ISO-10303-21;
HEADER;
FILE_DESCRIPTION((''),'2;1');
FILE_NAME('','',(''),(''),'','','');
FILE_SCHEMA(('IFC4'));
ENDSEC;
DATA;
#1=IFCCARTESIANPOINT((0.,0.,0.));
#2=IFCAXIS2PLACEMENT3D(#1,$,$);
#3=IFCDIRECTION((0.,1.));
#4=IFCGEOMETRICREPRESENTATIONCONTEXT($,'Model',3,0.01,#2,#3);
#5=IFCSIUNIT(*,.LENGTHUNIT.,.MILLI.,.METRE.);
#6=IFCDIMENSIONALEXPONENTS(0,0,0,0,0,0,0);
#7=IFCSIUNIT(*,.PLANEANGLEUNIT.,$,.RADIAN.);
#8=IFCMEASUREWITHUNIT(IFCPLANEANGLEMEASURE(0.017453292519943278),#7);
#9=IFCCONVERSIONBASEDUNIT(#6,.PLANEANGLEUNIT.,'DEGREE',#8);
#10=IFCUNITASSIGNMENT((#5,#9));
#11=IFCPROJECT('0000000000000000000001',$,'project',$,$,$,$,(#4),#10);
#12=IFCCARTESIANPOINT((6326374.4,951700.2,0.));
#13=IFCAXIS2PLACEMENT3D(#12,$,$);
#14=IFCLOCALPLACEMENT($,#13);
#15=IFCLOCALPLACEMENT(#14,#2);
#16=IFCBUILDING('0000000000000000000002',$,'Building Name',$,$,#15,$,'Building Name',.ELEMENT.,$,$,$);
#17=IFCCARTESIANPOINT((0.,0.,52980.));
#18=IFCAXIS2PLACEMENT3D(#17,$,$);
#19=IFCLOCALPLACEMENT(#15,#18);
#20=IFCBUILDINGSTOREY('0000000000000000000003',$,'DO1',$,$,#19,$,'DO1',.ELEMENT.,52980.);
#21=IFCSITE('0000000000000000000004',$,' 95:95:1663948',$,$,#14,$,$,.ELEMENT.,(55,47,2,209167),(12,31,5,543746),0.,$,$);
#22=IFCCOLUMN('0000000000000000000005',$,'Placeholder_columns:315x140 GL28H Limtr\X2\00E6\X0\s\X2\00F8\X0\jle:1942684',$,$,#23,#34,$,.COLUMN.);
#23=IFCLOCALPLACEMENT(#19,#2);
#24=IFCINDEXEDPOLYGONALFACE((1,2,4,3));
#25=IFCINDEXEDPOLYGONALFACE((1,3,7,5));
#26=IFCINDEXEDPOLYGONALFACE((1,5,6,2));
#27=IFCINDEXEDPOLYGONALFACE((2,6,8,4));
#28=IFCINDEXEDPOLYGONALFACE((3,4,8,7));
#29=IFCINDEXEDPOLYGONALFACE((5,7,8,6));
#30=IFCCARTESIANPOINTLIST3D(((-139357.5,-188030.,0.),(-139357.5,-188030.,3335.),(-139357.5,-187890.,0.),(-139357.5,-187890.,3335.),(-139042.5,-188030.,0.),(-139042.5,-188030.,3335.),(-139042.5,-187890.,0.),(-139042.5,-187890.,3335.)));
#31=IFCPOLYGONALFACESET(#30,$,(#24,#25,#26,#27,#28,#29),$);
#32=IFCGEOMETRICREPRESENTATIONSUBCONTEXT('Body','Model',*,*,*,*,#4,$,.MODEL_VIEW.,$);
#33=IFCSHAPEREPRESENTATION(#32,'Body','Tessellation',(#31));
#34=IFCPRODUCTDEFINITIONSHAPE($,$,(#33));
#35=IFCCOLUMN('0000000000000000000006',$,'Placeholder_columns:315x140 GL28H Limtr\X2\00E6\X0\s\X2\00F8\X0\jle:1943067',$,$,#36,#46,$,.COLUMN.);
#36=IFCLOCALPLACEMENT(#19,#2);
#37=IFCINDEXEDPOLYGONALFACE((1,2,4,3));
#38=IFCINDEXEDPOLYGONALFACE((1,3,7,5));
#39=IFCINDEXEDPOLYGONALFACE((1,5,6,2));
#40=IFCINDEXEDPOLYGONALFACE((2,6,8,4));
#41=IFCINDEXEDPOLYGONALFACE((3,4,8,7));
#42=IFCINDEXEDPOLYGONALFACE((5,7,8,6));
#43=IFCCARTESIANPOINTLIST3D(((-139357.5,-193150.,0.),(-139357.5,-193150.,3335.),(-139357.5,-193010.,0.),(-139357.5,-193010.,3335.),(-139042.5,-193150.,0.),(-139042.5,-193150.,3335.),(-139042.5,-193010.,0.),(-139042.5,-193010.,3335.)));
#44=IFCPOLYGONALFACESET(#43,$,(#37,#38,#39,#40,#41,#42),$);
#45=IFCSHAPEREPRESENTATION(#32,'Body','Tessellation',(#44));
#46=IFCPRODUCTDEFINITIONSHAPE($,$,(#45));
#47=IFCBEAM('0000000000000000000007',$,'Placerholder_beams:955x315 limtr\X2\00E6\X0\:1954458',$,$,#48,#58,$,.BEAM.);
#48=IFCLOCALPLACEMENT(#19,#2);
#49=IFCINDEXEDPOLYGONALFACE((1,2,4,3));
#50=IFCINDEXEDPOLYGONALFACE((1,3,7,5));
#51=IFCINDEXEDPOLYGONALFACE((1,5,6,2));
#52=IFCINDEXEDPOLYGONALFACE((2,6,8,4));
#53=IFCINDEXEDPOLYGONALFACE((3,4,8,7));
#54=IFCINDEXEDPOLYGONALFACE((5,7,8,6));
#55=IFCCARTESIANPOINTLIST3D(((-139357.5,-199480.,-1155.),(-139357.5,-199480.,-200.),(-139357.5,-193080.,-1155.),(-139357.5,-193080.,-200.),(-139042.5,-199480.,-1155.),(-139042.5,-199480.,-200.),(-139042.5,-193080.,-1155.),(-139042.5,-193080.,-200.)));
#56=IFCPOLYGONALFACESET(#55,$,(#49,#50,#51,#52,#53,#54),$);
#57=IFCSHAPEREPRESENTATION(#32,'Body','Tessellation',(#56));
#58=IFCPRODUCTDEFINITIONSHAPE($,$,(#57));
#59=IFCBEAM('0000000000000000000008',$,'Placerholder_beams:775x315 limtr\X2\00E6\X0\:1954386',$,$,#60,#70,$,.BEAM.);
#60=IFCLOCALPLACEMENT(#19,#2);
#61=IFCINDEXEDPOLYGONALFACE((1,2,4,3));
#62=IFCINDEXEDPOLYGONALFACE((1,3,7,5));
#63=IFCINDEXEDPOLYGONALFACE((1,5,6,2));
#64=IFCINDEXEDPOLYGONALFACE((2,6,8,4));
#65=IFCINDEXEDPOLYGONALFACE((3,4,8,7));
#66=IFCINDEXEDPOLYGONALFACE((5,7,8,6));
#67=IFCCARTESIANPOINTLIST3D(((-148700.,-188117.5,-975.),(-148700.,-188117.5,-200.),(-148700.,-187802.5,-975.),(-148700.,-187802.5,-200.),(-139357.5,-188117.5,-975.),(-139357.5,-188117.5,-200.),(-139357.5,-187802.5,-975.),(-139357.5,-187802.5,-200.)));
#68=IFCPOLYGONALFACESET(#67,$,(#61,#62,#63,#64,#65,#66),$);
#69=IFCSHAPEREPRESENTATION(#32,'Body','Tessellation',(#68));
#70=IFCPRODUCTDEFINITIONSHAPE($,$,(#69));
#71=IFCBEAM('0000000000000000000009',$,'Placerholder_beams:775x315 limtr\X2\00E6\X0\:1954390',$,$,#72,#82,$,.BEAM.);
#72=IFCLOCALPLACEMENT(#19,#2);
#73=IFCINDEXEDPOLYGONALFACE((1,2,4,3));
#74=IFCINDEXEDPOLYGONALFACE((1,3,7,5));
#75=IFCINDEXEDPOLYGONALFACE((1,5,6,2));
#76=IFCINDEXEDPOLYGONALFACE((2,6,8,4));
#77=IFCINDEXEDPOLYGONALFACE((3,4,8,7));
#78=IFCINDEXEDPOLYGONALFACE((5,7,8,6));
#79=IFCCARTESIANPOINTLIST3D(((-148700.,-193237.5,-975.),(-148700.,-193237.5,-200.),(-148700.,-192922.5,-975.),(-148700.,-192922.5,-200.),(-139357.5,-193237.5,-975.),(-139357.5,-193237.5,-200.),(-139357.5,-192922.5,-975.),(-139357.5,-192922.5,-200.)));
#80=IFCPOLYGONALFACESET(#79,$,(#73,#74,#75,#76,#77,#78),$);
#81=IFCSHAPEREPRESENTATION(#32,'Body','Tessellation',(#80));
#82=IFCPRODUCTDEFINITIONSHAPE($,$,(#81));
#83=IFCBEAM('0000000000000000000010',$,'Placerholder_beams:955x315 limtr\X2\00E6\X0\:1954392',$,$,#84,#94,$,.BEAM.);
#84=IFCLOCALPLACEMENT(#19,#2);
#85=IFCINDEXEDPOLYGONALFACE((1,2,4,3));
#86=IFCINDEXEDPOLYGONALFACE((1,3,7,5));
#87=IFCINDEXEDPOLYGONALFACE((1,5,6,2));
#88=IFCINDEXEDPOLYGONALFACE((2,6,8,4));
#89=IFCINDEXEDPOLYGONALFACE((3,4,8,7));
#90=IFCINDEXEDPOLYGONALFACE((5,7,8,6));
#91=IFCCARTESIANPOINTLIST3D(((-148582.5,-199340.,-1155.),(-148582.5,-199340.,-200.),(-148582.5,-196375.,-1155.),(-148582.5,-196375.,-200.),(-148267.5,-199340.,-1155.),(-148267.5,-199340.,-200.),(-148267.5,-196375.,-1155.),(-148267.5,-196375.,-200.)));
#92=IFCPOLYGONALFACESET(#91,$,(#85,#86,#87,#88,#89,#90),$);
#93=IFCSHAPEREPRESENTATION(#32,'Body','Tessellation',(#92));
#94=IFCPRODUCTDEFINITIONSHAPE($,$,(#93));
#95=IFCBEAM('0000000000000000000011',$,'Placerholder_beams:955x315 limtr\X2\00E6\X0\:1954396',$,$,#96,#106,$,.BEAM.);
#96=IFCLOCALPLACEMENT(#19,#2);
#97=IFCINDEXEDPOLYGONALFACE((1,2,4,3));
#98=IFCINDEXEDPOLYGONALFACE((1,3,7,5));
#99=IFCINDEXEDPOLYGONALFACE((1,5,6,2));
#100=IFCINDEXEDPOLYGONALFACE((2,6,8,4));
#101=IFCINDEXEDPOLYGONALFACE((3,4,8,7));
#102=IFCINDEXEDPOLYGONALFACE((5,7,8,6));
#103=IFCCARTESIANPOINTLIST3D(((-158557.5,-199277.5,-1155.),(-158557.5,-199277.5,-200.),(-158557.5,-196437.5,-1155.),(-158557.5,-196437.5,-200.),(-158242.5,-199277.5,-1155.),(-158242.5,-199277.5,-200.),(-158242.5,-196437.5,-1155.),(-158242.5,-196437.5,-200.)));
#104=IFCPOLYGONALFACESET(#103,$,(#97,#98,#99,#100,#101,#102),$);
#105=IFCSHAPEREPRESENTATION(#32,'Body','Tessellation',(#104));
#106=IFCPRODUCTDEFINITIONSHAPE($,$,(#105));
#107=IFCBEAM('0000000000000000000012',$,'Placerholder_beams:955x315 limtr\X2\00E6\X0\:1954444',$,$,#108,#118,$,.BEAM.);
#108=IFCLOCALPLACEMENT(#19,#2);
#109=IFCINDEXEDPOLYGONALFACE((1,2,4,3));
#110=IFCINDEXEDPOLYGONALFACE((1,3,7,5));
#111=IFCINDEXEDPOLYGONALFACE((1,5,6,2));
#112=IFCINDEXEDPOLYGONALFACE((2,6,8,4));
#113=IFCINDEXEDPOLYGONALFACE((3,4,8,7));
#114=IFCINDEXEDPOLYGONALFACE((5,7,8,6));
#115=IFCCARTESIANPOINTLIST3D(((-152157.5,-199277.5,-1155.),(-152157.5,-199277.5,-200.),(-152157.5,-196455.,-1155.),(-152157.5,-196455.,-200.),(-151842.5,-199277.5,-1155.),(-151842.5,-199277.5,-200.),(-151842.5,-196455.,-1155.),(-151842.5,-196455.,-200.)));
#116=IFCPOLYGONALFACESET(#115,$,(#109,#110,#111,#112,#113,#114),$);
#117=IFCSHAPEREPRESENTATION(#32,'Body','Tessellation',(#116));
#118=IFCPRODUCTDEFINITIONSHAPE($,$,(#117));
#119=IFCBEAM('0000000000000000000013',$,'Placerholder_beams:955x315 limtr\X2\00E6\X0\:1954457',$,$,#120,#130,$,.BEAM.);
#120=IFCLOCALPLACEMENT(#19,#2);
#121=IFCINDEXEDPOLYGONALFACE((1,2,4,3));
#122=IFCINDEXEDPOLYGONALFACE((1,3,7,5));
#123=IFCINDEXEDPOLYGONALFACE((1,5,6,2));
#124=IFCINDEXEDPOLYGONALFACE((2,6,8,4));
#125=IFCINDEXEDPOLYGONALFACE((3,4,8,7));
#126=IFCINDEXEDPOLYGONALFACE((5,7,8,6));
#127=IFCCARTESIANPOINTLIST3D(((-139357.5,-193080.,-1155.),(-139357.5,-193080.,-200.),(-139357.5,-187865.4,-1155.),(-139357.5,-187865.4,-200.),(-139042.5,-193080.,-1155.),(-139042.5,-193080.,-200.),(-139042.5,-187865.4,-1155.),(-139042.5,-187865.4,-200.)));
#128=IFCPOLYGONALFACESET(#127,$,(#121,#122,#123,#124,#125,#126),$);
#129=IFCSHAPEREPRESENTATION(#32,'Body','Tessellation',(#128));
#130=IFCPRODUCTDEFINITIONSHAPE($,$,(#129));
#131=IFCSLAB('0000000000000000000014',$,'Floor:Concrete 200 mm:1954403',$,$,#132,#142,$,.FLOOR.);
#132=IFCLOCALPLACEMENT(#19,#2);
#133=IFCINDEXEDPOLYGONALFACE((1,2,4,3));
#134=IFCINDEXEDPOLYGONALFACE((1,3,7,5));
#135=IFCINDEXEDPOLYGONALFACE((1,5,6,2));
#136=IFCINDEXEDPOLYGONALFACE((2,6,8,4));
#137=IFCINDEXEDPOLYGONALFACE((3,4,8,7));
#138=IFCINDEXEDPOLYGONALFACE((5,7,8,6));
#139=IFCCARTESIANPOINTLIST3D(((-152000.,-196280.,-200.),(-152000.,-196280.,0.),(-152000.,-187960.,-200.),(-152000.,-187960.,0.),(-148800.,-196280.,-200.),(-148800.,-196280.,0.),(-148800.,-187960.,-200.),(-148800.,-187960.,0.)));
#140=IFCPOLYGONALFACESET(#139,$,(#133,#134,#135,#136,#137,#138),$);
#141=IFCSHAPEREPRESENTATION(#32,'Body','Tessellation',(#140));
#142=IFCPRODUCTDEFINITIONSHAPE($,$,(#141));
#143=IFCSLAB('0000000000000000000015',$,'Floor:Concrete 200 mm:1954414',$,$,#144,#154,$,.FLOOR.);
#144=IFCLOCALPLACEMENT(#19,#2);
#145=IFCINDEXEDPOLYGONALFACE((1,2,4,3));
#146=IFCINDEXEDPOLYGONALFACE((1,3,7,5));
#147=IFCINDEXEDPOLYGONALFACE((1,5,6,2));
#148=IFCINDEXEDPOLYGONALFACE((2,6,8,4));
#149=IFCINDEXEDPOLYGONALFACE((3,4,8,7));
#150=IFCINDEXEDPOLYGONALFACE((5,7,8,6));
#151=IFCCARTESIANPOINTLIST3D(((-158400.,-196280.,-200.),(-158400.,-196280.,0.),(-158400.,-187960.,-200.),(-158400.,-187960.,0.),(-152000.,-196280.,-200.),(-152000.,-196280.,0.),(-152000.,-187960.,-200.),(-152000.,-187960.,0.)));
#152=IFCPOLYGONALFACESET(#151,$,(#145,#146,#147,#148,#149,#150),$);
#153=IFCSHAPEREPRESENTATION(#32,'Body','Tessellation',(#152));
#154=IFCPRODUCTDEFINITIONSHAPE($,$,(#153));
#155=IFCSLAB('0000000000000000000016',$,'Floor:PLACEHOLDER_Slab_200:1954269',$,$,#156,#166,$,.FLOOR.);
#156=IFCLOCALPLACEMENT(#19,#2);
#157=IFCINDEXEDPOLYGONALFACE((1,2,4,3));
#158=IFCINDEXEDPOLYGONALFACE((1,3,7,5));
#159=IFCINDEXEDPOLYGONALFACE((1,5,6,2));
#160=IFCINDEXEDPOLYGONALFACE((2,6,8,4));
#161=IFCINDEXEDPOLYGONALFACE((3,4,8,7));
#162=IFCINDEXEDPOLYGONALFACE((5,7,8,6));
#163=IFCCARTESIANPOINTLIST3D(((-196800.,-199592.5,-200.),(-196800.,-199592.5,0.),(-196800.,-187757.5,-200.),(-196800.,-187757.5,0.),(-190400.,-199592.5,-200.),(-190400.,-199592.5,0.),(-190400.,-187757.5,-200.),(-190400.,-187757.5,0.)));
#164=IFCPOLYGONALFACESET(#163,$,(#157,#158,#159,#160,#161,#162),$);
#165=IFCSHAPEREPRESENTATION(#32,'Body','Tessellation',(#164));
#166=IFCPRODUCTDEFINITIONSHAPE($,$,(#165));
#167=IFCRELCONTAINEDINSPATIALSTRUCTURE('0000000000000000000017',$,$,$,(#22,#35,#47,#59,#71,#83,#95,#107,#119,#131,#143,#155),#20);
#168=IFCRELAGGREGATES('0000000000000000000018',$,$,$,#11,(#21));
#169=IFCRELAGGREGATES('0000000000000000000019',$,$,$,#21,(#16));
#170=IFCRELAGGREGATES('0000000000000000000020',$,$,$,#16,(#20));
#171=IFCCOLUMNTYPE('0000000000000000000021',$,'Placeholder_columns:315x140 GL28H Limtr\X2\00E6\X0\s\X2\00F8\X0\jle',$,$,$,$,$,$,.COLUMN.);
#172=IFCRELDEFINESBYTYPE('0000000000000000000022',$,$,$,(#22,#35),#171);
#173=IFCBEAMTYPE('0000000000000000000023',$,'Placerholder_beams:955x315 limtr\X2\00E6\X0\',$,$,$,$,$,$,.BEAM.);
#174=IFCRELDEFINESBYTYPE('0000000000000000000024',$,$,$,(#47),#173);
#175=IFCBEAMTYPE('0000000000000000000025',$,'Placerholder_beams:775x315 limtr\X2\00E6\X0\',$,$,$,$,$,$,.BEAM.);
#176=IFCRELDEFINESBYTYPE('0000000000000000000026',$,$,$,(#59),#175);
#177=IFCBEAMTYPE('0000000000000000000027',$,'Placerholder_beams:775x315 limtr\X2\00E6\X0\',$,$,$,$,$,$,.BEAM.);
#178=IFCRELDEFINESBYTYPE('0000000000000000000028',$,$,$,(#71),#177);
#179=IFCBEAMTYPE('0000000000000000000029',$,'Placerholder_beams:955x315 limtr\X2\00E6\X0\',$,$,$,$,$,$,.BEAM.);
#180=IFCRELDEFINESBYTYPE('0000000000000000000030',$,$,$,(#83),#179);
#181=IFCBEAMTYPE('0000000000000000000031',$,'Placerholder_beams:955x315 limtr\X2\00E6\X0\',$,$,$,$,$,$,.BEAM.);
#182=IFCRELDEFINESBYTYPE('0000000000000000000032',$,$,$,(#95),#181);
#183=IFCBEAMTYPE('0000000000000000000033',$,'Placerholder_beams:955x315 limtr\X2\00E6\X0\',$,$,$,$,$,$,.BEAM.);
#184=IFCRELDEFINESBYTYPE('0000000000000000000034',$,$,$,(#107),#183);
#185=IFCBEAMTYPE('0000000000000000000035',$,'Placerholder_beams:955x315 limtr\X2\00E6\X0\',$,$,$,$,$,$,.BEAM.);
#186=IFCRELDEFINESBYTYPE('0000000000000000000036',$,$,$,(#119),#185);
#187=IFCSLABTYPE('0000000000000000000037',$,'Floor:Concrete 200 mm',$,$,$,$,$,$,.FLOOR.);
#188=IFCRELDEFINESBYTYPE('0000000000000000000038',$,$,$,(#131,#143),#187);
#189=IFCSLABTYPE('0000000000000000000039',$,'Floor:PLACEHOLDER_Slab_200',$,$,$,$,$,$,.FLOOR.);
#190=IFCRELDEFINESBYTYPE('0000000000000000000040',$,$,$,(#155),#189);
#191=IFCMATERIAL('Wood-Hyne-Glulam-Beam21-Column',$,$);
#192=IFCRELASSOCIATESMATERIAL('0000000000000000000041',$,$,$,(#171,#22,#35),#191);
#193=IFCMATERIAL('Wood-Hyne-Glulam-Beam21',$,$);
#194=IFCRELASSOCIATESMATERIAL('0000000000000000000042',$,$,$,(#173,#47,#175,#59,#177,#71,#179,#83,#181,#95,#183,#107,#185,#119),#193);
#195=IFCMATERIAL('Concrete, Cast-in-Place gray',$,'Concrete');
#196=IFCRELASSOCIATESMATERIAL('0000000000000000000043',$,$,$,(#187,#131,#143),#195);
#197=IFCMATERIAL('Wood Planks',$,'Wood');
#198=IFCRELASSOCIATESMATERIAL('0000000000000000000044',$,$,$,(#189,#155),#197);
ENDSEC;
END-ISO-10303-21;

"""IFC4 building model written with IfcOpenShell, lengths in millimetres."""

from ifc_helpers import new_model, entity, si_unit, converted_unit, direction, frame, origin, place, context, subcontext, project, spatial, indexed_curve, outline, extrude, source, transform, mapped, material, type_object, type_shapes, element, save


model = new_model("IFC4")

# Units and contexts
model_context = context("Model", 3, precision=0.01, world=origin(), true_north=direction((0.0, 1.0)))
body_context = subcontext(model_context, "Body", "Model", "MODEL_VIEW")
ifc_project = project(units=[si_unit("LENGTHUNIT", "METRE", prefix="MILLI"), converted_unit("PLANEANGLEUNIT", "DEGREE", entity("IfcPlaneAngleMeasure", 0.017453292519943278), si_unit("PLANEANGLEUNIT", "RADIAN"), dimensions=[0, 0, 0, 0, 0, 0, 0])], contexts=[model_context])

# Site, building, storey
site_placement = place(None, frame((6326374.4, 951700.2, 0.0)))
site = spatial("IfcSite", under=ifc_project, at=site_placement, Name=" 95:95:1663948", CompositionType="ELEMENT", RefLatitude=(55, 47, 2, 209167), RefLongitude=(12, 31, 5, 543746), RefElevation=0.0)
building_placement = place(site_placement, origin())
building = spatial("IfcBuilding", under=site, at=building_placement, Name="Building Name", LongName="Building Name", CompositionType="ELEMENT")
storey_placement = place(building_placement, frame((0.0, 0.0, 52980.0)))
storey = spatial("IfcBuildingStorey", under=building, at=storey_placement, Name="DO1", LongName="DO1", CompositionType="ELEMENT", Elevation=52980.0)

# Columns
ifc_material_1 = material(Name="Wood-Hyne-Glulam-Beam21-Column")
column_type = type_object("IfcColumnType", Name="Placeholder_columns:315x140 GL28H Limtræsøjle", PredefinedType="COLUMN", material=ifc_material_1)
shared_shape_1 = source(origin(), body_context, "Body", "SweptSolid", [
    extrude(outline(indexed_curve([(-157.5, -70.0), (157.5, -70.0), (157.5, 70.0), (-157.5, 70.0), (-157.5, -70.0)], self_intersect=False)), frame((0.0, 0.0, 52980.0), z_axis=(0.0, 0.0, 1.0), x_axis=(-1.0, 0.0, 0.0)), (0.0, 0.0, 1.0), 3335.0),
])
type_shapes(column_type, [shared_shape_1])
for number, where, name in (
    (1, (-139200.0, -187960.0, -52980.0), "Placeholder_columns:315x140 GL28H Limtræsøjle:1942684"),
    (2, (-139200.0, -193080.0, -52980.0), "Placeholder_columns:315x140 GL28H Limtræsøjle:1943067"),
):
    element("IfcColumn", number, at=place(storey_placement, frame(where)), inside=storey, type_object=column_type, material=ifc_material_1, Name=name, PredefinedType="COLUMN", context=body_context, shape_type="MappedRepresentation", body=[
        mapped(shared_shape_1, transform((0.0, 0.0, 0.0), scale=1.0)),
    ])

# Beams
ifc_material_2 = material(Name="Wood-Hyne-Glulam-Beam21")
beam_type_1 = type_object("IfcBeamType", Name="Placerholder_beams:955x315 limtræ", PredefinedType="BEAM", material=ifc_material_2)
shared_shape_2 = source(origin(), body_context, "Body", "SweptSolid", [
    extrude(outline(indexed_curve([(-3200.0, -157.5), (3200.0, -157.5), (3200.0, 157.5), (-3200.0, 157.5), (-3200.0, -157.5)], self_intersect=False)), frame((0.0, 0.0, -477.5)), (0.0, 0.0, 1.0), 955.0),
])
type_shapes(beam_type_1, [shared_shape_2])
beam_1_placement = place(storey_placement, frame((-139200.0, -196280.0, -677.5), z_axis=(0.0, 0.0, 1.0), x_axis=(0.0, -1.0, 0.0)))
element("IfcBeam", 3, at=beam_1_placement, inside=storey, type_object=beam_type_1, material=ifc_material_2, Name="Placerholder_beams:955x315 limtræ:1954458", PredefinedType="BEAM", context=body_context, shape_type="MappedRepresentation", body=[
    mapped(shared_shape_2, transform((0.0, 0.0, 0.0), scale=1.0)),
])
beam_type_2 = type_object("IfcBeamType", Name="Placerholder_beams:775x315 limtræ", PredefinedType="BEAM", material=ifc_material_2)
shared_shape_3 = source(origin(), body_context, "Body", "SweptSolid", [
    extrude(outline(indexed_curve([(-4671.3, -157.5), (4671.3, -157.5), (4671.3, 157.5), (-4671.3, 157.5), (-4671.3, -157.5)], self_intersect=False)), frame((28.7, 0.0, -387.5)), (0.0, 0.0, 1.0), 775.0),
])
type_shapes(beam_type_2, [shared_shape_3])
beam_2_placement = place(storey_placement, frame((-144000.0, -187960.0, -587.5), z_axis=(0.0, 0.0, 1.0), x_axis=(-1.0, 0.0, 0.0)))
element("IfcBeam", 4, at=beam_2_placement, inside=storey, type_object=beam_type_2, material=ifc_material_2, Name="Placerholder_beams:775x315 limtræ:1954386", PredefinedType="BEAM", context=body_context, shape_type="MappedRepresentation", body=[
    mapped(shared_shape_3, transform((0.0, 0.0, 0.0), scale=1.0)),
])
beam_type_3 = type_object("IfcBeamType", Name="Placerholder_beams:775x315 limtræ", PredefinedType="BEAM", material=ifc_material_2)
shared_shape_4 = source(origin(), body_context, "Body", "SweptSolid", [
    extrude(outline(indexed_curve([(-4671.3, -157.5), (4671.3, -157.5), (4671.3, 157.5), (-4671.3, 157.5), (-4671.3, -157.5)], self_intersect=False)), frame((-28.7, 0.0, -387.5)), (0.0, 0.0, 1.0), 775.0),
])
type_shapes(beam_type_3, [shared_shape_4])
beam_3_placement = place(storey_placement, frame((-144000.0, -193080.0, -587.5)))
element("IfcBeam", 5, at=beam_3_placement, inside=storey, type_object=beam_type_3, material=ifc_material_2, Name="Placerholder_beams:775x315 limtræ:1954390", PredefinedType="BEAM", context=body_context, shape_type="MappedRepresentation", body=[
    mapped(shared_shape_4, transform((0.0, 0.0, 0.0), scale=1.0)),
])
beam_type_4 = type_object("IfcBeamType", Name="Placerholder_beams:955x315 limtræ", PredefinedType="BEAM", material=ifc_material_2)
shared_shape_5 = source(origin(), body_context, "Body", "SweptSolid", [
    extrude(outline(indexed_curve([(-1482.5, -157.5), (1482.5, -157.5), (1482.5, 157.5), (-1482.5, 157.5), (-1482.5, -157.5)], self_intersect=False)), frame((22.5, 0.0, -477.5)), (0.0, 0.0, 1.0), 955.0),
])
type_shapes(beam_type_4, [shared_shape_5])
beam_4_placement = place(storey_placement, frame((-148425.0, -197880.0, -677.5), z_axis=(0.0, 0.0, 1.0), x_axis=(0.0, 1.0, 0.0)))
element("IfcBeam", 6, at=beam_4_placement, inside=storey, type_object=beam_type_4, material=ifc_material_2, Name="Placerholder_beams:955x315 limtræ:1954392", PredefinedType="BEAM", context=body_context, shape_type="MappedRepresentation", body=[
    mapped(shared_shape_5, transform((0.0, 0.0, 0.0), scale=1.0)),
])
beam_type_5 = type_object("IfcBeamType", Name="Placerholder_beams:955x315 limtræ", PredefinedType="BEAM", material=ifc_material_2)
shared_shape_6 = source(origin(), body_context, "Body", "SweptSolid", [
    extrude(outline(indexed_curve([(-1420.0, -157.5), (1420.0, -157.5), (1420.0, 157.5), (-1420.0, 157.5), (-1420.0, -157.5)], self_intersect=False)), frame((0.0, 0.0, -477.5)), (0.0, 0.0, 1.0), 955.0),
])
type_shapes(beam_type_5, [shared_shape_6])
beam_5_placement = place(storey_placement, frame((-158400.0, -197857.5, -677.5), z_axis=(0.0, 0.0, 1.0), x_axis=(0.0, 1.0, 0.0)))
element("IfcBeam", 7, at=beam_5_placement, inside=storey, type_object=beam_type_5, material=ifc_material_2, Name="Placerholder_beams:955x315 limtræ:1954396", PredefinedType="BEAM", context=body_context, shape_type="MappedRepresentation", body=[
    mapped(shared_shape_6, transform((0.0, 0.0, 0.0), scale=1.0)),
])
beam_type_6 = type_object("IfcBeamType", Name="Placerholder_beams:955x315 limtræ", PredefinedType="BEAM", material=ifc_material_2)
shared_shape_7 = source(origin(), body_context, "Body", "SweptSolid", [
    extrude(outline(indexed_curve([(-1411.2, -157.5), (1411.2, -157.5), (1411.2, 157.5), (-1411.2, 157.5), (-1411.2, -157.5)], self_intersect=False)), frame((28.8, 0.0, -477.5)), (0.0, 0.0, 1.0), 955.0),
])
type_shapes(beam_type_6, [shared_shape_7])
beam_6_placement = place(storey_placement, frame((-152000.0, -197895.0, -677.5), z_axis=(0.0, 0.0, 1.0), x_axis=(0.0, 1.0, 0.0)))
element("IfcBeam", 8, at=beam_6_placement, inside=storey, type_object=beam_type_6, material=ifc_material_2, Name="Placerholder_beams:955x315 limtræ:1954444", PredefinedType="BEAM", context=body_context, shape_type="MappedRepresentation", body=[
    mapped(shared_shape_7, transform((0.0, 0.0, 0.0), scale=1.0)),
])
beam_type_7 = type_object("IfcBeamType", Name="Placerholder_beams:955x315 limtræ", PredefinedType="BEAM", material=ifc_material_2)
shared_shape_8 = source(origin(), body_context, "Body", "SweptSolid", [
    extrude(outline(indexed_curve([(-2607.3, -157.5), (2607.3, -157.5), (2607.3, 157.5), (-2607.3, 157.5), (-2607.3, -157.5)], self_intersect=False)), frame((47.3, 0.0, -477.5)), (0.0, 0.0, 1.0), 955.0),
])
type_shapes(beam_type_7, [shared_shape_8])
beam_7_placement = place(storey_placement, frame((-139200.0, -190520.0, -677.5), z_axis=(0.0, 0.0, 1.0), x_axis=(0.0, 1.0, 0.0)))
element("IfcBeam", 9, at=beam_7_placement, inside=storey, type_object=beam_type_7, material=ifc_material_2, Name="Placerholder_beams:955x315 limtræ:1954457", PredefinedType="BEAM", context=body_context, shape_type="MappedRepresentation", body=[
    mapped(shared_shape_8, transform((0.0, 0.0, 0.0), scale=1.0)),
])

# Slabs
ifc_material_3 = material(Name="Concrete, Cast-in-Place gray", Category="Concrete")
slab_type_1 = type_object("IfcSlabType", Name="Floor:Concrete 200 mm", PredefinedType="FLOOR", material=ifc_material_3)
slab_1_placement = place(storey_placement, origin())
element("IfcSlab", 10, at=slab_1_placement, inside=storey, type_object=slab_type_1, material=ifc_material_3, Name="Floor:Concrete 200 mm:1954403", PredefinedType="FLOOR", context=body_context, shape_type="SweptSolid", body=[
    extrude(outline(indexed_curve([(-4160.0, -1600.0), (4160.0, -1600.0), (4160.0, 1600.0), (-4160.0, 1600.0), (-4160.0, -1600.0)], self_intersect=False)), frame((-150400.0, -192120.0, 0.0), z_axis=(0.0, 0.0, -1.0), x_axis=(0.0, 1.0, 0.0)), (0.0, 0.0, 1.0), 200.0),
])
slab_2_placement = place(storey_placement, origin())
element("IfcSlab", 11, at=slab_2_placement, inside=storey, type_object=slab_type_1, material=ifc_material_3, Name="Floor:Concrete 200 mm:1954414", PredefinedType="FLOOR", context=body_context, shape_type="SweptSolid", body=[
    extrude(outline(indexed_curve([(-4160.0, -3200.0), (4160.0, -3200.0), (4160.0, 3200.0), (-4160.0, 3200.0), (-4160.0, -3200.0)], self_intersect=False)), frame((-155200.0, -192120.0, 0.0), z_axis=(0.0, 0.0, -1.0), x_axis=(0.0, 1.0, 0.0)), (0.0, 0.0, 1.0), 200.0),
])
ifc_material_4 = material(Name="Wood Planks", Category="Wood")
slab_type_2 = type_object("IfcSlabType", Name="Floor:PLACEHOLDER_Slab_200", PredefinedType="FLOOR", material=ifc_material_4)
slab_3_placement = place(storey_placement, origin())
element("IfcSlab", 12, at=slab_3_placement, inside=storey, type_object=slab_type_2, material=ifc_material_4, Name="Floor:PLACEHOLDER_Slab_200:1954269", PredefinedType="FLOOR", context=body_context, shape_type="SweptSolid", body=[
    extrude(outline(indexed_curve([(-5917.5, -3200.0), (5917.5, -3200.0), (5917.5, 3200.0), (-5917.5, 3200.0), (-5917.5, -3200.0)], self_intersect=False)), frame((-193600.0, -193675.0, 0.0), z_axis=(0.0, 0.0, -1.0), x_axis=(0.0, 1.0, 0.0)), (0.0, 0.0, 1.0), 200.0),
])

save(model, "model.ifc")
